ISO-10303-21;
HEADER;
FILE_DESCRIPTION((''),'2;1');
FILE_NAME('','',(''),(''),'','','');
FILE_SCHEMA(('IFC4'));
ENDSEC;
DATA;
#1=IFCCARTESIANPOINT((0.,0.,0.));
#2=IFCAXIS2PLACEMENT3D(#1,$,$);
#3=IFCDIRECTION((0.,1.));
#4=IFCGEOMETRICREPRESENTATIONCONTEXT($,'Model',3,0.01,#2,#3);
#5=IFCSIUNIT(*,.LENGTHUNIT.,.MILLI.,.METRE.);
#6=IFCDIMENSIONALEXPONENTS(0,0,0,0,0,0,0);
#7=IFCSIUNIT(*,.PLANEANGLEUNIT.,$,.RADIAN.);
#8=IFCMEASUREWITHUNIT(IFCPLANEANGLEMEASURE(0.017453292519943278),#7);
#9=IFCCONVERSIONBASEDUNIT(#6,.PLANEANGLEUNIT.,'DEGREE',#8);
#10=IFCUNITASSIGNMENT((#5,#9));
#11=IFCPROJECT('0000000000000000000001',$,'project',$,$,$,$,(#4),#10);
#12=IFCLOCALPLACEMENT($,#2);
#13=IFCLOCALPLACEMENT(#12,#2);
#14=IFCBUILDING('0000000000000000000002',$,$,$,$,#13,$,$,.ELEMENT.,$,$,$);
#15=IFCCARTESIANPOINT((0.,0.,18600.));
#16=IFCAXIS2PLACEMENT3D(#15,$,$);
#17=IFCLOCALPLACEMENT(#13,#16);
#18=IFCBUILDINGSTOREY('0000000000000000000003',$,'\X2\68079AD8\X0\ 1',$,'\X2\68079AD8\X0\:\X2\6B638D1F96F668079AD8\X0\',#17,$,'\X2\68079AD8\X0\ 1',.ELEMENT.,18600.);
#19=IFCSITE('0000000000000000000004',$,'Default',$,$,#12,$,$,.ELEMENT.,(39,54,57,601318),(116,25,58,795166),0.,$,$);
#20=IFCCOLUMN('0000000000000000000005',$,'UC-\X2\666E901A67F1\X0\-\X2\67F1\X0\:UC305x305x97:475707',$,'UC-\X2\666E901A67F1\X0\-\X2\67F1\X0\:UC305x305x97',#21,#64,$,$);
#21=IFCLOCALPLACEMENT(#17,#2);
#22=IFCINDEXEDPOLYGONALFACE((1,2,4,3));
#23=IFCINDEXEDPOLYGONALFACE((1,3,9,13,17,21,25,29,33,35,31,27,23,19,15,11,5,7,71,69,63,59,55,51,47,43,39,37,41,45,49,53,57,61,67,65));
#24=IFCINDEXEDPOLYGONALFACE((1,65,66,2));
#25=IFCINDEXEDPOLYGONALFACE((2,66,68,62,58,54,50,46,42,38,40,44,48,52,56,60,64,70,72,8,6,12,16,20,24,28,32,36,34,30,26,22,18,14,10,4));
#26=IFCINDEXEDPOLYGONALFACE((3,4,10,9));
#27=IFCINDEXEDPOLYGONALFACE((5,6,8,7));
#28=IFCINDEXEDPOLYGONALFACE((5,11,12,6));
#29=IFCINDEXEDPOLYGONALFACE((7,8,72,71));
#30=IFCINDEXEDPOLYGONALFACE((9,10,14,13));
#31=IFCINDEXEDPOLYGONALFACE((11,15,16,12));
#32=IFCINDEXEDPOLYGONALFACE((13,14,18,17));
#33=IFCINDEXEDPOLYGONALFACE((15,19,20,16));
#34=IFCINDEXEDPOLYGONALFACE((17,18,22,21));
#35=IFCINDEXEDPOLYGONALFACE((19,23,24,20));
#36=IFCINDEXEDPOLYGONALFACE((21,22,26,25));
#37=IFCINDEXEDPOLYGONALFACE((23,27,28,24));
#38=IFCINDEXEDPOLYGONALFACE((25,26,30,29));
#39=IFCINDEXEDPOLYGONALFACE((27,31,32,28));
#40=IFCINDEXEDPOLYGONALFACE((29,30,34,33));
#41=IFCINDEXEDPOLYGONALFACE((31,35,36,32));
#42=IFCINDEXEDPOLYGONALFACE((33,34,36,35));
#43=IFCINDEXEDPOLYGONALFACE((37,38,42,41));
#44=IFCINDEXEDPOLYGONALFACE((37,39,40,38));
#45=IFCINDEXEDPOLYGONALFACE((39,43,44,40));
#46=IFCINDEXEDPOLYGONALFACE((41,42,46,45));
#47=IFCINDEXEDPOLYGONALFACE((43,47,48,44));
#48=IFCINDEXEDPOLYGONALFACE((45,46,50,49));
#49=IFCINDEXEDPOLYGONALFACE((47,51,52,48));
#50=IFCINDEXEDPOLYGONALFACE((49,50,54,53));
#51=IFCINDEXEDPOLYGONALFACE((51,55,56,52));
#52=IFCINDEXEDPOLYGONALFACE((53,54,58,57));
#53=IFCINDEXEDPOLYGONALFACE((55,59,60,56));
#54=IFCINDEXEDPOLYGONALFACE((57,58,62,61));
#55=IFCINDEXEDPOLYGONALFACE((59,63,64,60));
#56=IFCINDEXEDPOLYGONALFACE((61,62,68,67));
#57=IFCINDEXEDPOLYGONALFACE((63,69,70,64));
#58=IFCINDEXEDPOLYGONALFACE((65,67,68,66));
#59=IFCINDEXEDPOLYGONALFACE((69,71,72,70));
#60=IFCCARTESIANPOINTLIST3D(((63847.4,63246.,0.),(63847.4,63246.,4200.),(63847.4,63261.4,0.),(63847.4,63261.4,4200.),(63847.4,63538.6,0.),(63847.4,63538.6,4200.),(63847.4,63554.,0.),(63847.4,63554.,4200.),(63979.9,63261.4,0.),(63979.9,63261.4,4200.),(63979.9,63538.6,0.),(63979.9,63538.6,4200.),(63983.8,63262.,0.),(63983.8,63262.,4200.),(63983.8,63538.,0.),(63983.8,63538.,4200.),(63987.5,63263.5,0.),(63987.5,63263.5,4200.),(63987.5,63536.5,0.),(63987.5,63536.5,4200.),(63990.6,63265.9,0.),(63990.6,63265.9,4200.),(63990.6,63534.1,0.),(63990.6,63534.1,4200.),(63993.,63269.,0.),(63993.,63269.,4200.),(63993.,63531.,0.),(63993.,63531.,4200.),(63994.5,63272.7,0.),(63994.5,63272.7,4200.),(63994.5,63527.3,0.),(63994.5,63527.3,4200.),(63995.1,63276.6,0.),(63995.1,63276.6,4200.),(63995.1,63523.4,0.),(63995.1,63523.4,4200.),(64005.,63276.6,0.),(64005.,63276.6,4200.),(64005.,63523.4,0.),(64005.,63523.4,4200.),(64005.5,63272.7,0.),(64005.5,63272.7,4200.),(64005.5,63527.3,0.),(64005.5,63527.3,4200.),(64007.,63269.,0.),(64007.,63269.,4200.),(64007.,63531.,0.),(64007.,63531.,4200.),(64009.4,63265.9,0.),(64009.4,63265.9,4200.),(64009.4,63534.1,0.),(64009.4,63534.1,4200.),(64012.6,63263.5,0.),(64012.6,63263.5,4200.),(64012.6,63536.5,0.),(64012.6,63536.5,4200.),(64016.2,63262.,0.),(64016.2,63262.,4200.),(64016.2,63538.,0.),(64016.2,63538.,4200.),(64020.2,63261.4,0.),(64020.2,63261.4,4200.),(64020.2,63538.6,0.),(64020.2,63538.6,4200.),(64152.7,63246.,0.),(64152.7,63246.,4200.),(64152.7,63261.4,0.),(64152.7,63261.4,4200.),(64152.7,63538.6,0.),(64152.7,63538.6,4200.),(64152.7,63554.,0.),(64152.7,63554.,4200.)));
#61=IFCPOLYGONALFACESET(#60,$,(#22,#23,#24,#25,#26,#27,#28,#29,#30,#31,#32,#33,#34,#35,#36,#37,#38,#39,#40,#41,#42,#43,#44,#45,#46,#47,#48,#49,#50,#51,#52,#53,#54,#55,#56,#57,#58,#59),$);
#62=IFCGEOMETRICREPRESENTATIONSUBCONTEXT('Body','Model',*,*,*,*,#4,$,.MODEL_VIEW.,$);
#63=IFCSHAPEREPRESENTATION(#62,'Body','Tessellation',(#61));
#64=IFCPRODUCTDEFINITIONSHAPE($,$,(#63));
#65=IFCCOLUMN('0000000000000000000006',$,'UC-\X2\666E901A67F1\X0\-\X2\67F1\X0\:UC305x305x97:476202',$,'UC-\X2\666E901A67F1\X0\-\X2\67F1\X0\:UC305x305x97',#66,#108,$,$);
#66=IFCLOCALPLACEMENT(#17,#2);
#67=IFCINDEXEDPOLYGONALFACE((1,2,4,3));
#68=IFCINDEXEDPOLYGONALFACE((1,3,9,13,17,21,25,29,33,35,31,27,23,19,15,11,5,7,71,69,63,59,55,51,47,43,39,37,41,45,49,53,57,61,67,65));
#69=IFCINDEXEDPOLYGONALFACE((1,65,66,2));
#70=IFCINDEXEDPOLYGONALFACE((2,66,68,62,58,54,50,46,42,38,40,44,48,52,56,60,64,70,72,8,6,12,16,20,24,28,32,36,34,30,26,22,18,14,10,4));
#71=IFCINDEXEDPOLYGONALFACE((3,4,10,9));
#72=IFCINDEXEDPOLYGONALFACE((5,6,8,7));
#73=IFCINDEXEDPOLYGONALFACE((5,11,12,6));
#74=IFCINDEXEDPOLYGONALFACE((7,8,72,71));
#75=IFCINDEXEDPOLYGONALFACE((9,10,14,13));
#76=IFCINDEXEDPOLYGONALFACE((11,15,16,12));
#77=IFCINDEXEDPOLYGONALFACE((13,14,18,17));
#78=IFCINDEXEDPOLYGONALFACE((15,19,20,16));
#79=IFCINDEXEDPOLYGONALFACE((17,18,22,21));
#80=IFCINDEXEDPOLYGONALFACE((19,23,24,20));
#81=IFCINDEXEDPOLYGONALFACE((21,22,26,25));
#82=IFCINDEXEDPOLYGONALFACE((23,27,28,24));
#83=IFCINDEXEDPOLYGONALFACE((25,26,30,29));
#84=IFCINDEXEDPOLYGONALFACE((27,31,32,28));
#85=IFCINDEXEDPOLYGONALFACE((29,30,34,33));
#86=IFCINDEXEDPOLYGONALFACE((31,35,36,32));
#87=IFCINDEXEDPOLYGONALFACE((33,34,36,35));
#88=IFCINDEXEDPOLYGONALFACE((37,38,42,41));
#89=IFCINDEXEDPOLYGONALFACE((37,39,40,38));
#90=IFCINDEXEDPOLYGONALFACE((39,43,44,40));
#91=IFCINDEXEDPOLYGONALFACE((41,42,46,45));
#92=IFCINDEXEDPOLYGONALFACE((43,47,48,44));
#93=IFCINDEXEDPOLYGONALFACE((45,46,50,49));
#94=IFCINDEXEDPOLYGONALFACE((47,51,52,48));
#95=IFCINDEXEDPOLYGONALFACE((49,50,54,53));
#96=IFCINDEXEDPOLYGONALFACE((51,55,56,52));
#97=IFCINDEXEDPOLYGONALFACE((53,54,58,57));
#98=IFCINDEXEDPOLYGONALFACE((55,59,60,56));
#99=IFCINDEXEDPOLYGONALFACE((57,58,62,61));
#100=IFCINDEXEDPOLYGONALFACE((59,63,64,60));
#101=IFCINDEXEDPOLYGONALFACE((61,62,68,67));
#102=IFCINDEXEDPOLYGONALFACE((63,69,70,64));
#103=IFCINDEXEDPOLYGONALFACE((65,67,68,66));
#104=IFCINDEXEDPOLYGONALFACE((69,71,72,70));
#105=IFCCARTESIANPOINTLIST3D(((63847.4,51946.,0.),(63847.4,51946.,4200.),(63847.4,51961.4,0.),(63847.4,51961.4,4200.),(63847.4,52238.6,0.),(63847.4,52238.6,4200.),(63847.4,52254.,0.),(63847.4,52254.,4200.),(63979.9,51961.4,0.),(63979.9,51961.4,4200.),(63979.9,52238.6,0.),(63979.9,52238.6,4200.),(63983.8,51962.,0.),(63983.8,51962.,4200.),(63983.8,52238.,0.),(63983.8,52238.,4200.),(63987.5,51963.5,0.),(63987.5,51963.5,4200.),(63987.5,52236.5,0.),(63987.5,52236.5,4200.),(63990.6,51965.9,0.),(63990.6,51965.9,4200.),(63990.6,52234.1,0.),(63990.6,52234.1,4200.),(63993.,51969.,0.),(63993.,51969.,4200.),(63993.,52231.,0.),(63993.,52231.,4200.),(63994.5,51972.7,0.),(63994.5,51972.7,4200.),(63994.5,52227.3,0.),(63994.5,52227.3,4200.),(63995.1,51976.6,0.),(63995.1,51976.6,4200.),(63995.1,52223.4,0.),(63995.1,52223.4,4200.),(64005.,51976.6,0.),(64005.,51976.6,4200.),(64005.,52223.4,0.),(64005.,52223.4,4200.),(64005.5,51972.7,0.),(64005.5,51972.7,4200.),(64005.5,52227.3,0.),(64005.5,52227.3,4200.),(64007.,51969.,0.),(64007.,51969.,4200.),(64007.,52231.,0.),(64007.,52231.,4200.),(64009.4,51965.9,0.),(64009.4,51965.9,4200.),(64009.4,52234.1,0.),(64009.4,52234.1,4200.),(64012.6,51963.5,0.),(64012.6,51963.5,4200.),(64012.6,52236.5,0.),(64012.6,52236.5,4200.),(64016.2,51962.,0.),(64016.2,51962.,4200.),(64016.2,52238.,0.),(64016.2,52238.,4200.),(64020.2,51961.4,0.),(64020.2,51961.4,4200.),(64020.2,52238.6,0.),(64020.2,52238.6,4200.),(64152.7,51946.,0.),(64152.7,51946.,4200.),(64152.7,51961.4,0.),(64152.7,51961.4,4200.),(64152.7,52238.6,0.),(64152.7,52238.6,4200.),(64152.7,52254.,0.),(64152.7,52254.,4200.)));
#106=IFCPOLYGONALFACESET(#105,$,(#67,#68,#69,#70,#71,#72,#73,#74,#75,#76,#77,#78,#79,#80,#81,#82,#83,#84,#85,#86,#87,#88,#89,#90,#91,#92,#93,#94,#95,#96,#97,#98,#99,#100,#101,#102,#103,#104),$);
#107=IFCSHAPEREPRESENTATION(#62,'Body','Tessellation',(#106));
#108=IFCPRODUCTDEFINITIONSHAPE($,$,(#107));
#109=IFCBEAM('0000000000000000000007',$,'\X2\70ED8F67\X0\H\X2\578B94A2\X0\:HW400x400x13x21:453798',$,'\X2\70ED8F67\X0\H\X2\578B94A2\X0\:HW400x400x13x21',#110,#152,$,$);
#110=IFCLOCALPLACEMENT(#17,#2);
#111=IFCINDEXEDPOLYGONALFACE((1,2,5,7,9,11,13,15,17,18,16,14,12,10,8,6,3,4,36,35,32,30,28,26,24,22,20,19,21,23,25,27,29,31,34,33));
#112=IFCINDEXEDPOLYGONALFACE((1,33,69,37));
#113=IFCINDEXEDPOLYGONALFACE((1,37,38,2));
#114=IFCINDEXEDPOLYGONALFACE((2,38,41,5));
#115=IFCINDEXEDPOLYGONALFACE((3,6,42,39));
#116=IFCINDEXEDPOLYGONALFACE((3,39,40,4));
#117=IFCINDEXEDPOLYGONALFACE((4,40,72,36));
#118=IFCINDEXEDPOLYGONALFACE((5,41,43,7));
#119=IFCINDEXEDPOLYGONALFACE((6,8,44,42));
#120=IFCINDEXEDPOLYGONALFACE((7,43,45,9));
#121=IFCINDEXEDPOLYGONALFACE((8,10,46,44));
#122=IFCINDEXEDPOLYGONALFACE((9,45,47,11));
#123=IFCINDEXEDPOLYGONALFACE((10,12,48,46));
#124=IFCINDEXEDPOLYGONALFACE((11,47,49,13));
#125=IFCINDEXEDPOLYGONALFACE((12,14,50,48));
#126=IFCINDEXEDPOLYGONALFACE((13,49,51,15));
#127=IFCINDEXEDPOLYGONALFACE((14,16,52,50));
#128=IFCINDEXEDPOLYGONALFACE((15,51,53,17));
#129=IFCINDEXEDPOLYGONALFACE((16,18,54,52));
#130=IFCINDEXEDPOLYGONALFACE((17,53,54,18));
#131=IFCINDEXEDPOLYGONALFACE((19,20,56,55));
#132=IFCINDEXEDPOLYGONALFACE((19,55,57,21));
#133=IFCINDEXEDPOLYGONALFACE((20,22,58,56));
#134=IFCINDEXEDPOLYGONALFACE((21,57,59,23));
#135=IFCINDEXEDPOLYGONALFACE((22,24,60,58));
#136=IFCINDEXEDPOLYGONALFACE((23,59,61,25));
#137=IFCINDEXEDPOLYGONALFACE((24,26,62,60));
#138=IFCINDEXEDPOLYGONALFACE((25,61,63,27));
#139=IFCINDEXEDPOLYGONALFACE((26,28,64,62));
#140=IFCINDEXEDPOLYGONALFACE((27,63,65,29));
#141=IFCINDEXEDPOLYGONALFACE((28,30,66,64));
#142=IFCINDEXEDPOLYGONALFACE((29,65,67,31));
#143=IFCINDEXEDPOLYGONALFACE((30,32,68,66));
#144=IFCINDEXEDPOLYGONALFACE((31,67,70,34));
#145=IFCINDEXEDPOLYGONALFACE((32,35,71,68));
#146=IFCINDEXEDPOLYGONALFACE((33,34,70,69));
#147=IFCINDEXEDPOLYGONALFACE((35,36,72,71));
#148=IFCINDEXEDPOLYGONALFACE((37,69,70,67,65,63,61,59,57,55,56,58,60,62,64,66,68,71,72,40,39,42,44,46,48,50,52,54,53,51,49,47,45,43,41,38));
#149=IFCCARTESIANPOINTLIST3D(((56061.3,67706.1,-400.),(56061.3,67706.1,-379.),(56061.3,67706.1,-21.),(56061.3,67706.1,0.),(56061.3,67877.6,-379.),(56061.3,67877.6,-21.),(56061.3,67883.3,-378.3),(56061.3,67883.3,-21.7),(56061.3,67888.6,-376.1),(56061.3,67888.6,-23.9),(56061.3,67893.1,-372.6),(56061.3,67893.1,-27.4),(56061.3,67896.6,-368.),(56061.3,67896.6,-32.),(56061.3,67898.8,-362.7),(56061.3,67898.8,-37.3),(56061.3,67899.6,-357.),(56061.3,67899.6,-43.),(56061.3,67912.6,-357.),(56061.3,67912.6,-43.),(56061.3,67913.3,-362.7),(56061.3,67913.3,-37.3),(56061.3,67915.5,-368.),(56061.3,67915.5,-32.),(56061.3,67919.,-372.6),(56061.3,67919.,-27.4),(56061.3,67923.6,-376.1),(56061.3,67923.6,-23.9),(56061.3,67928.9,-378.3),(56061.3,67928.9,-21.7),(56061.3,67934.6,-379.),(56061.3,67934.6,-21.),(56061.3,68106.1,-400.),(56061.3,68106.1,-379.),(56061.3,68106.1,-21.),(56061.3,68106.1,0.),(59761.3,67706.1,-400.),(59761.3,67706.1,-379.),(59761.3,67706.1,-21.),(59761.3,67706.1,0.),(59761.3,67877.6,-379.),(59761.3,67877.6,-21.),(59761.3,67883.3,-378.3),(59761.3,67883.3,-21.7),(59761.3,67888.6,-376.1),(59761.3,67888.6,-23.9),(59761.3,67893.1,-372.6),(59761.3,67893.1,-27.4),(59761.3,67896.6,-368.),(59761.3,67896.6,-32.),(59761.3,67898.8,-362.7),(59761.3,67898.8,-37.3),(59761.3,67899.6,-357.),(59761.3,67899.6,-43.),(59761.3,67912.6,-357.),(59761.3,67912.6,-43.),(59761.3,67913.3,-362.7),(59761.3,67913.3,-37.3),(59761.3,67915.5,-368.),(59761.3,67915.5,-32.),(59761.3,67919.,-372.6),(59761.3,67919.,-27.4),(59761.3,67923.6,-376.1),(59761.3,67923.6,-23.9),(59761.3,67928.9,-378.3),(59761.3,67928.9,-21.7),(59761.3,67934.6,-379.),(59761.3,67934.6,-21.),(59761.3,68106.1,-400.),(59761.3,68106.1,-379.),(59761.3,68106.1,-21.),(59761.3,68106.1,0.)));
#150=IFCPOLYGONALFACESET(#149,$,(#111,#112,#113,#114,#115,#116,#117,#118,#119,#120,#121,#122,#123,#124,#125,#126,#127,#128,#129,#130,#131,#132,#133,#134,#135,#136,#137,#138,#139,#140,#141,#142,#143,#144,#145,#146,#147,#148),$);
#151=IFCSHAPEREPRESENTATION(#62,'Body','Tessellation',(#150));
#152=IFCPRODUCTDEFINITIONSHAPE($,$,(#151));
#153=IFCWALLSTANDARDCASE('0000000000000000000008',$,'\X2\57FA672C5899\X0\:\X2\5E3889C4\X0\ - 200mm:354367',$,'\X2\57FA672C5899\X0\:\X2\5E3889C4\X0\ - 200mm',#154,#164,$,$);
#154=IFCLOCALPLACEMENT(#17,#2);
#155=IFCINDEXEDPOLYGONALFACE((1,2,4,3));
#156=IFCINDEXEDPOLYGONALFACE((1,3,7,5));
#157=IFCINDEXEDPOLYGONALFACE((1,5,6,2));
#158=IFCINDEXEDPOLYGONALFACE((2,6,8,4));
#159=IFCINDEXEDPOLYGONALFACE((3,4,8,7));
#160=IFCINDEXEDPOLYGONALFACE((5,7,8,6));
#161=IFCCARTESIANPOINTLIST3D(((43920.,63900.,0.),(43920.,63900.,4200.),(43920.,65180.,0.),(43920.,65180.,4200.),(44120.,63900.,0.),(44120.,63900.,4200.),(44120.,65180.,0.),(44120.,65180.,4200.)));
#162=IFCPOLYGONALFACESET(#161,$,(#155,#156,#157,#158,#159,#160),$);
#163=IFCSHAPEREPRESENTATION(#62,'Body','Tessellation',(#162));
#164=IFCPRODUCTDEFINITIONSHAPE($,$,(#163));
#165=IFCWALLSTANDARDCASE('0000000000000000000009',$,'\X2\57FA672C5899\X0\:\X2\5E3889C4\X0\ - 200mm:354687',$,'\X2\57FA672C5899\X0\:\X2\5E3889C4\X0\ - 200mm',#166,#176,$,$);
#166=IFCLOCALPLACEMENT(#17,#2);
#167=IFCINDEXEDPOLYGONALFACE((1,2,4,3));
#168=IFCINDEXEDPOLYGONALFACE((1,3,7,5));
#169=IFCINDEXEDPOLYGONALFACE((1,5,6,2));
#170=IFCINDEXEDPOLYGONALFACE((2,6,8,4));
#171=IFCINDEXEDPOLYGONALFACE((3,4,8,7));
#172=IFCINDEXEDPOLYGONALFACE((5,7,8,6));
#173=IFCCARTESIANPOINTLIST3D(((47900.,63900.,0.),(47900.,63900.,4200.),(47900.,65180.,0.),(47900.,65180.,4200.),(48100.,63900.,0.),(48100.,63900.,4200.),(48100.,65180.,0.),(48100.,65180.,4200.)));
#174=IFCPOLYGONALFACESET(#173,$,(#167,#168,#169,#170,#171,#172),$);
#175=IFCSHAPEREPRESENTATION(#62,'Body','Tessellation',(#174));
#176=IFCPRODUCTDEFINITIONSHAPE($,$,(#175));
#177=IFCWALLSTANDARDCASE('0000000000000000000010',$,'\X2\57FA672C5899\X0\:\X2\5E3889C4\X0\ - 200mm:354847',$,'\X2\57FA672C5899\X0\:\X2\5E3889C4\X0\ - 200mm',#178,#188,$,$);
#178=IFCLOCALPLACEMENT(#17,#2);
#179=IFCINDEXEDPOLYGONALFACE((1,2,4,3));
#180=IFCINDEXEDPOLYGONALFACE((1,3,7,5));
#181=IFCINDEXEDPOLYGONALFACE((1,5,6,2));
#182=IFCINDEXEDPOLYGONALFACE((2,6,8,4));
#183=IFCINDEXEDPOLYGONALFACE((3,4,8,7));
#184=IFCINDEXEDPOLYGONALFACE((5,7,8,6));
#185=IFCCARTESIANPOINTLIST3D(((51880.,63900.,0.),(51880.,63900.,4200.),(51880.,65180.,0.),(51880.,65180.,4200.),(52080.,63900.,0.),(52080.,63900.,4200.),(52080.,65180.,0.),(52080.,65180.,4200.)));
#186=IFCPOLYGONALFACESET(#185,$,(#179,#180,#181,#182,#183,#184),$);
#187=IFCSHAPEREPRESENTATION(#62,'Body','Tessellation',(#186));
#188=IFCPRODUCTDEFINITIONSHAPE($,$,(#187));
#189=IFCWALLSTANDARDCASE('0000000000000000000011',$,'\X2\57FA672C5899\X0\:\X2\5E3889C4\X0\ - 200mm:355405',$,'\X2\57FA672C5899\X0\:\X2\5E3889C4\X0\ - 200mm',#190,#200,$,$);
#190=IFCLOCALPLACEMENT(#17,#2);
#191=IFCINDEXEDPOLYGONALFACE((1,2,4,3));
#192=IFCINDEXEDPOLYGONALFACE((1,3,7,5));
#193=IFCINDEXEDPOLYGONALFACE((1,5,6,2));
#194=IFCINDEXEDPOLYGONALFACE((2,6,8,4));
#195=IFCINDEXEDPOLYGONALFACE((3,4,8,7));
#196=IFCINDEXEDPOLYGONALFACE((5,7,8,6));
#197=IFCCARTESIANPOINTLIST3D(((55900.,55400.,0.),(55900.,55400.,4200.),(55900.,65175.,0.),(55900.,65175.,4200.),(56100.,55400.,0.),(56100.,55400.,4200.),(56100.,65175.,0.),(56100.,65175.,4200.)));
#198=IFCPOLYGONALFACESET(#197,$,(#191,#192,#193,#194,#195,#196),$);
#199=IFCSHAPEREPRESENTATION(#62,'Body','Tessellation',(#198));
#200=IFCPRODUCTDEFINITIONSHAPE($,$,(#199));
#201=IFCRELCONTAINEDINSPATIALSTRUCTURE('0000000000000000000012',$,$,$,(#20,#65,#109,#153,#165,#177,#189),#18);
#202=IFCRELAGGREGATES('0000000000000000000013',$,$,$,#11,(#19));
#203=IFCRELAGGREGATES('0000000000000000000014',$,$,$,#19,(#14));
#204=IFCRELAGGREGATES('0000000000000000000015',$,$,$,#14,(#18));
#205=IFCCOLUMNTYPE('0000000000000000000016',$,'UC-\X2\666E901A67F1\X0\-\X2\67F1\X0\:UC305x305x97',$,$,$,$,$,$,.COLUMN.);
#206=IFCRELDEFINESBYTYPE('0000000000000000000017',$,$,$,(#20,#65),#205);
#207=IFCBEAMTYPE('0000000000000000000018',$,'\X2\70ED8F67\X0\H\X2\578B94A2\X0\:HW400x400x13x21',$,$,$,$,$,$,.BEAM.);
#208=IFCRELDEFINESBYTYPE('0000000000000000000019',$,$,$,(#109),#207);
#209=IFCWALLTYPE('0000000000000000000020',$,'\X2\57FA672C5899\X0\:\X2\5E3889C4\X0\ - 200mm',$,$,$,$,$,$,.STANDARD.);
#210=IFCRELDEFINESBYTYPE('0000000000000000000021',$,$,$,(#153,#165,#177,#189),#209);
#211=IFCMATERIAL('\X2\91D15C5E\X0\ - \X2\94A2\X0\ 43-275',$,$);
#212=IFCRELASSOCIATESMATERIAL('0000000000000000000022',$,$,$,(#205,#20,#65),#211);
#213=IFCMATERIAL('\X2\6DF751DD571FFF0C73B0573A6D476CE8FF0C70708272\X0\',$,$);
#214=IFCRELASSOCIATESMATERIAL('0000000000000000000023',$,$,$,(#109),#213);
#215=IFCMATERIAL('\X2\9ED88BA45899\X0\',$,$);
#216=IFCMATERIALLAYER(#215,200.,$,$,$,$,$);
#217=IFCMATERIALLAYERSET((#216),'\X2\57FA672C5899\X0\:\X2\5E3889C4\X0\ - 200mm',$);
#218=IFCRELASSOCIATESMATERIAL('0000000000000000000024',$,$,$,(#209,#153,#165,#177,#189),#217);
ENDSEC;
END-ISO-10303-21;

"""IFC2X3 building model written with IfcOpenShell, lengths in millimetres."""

from ifc_helpers import new_model, entity, si_unit, converted_unit, direction, frame, frame_2d, origin, origin_2d_with_axis, place, context, subcontext, project, spatial, rectangle, i_section, extrude, source, transform, mapped, material, layer, layer_set, layer_usage, type_object, type_shapes, element, save


model = new_model("IFC2X3")

# Units and contexts
model_context = context("Model", 3, precision=0.01, world=origin(), true_north=direction((0.0, 1.0)))
body_context = subcontext(model_context, "Body", "Model", "MODEL_VIEW")
ifc_project = project(units=[si_unit("LENGTHUNIT", "METRE", prefix="MILLI"), converted_unit("PLANEANGLEUNIT", "DEGREE", entity("IfcPlaneAngleMeasure", 0.017453292519943278), si_unit("PLANEANGLEUNIT", "RADIAN"), dimensions=[0, 0, 0, 0, 0, 0, 0])], contexts=[model_context])

# Site, building, storey
site_placement = place(None, origin())
site = spatial("IfcSite", under=ifc_project, at=site_placement, Name="Default", CompositionType="ELEMENT", RefLatitude=(39, 54, 57, 601318), RefLongitude=(116, 25, 58, 795166), RefElevation=0.0)
building_placement = place(site_placement, origin())
building = spatial("IfcBuilding", under=site, at=building_placement, CompositionType="ELEMENT")
storey_placement = place(building_placement, frame((0.0, 0.0, 18600.0)))
storey = spatial("IfcBuildingStorey", under=building, at=storey_placement, Name="标高 1", ObjectType="标高:正负零标高", LongName="标高 1", CompositionType="ELEMENT", Elevation=18600.0)

# Columns
ifc_material_1 = material(Name="金属 - 钢 43-275")
column_type = type_object("IfcColumnType", Name="UC-普通柱-柱:UC305x305x97", PredefinedType="COLUMN", material=ifc_material_1)
shared_shape_1 = source(origin(), body_context, "Body", "SweptSolid", [
    extrude(i_section(OverallWidth=305.3, OverallDepth=307.9, WebThickness=9.9, FlangeThickness=15.4, FilletRadius=15.2, at=origin_2d_with_axis()), frame((0.0, 0.0, 18600.0), z_axis=(0.0, 0.0, 1.0), x_axis=(-1.0, 0.0, 0.0)), (0.0, 0.0, 1.0), 4200.0),
])
type_shapes(column_type, [shared_shape_1])
for number, where, name in (
    (1, (64000.0, 63400.0, -18600.0), "UC-普通柱-柱:UC305x305x97:475707"),
    (2, (64000.0, 52100.0, -18600.0), "UC-普通柱-柱:UC305x305x97:476202"),
):
    element("IfcColumn", number, at=place(storey_placement, frame(where)), inside=storey, type_object=column_type, material=ifc_material_1, Name=name, ObjectType="UC-普通柱-柱:UC305x305x97", context=body_context, shape_type="MappedRepresentation", body=[
        mapped(shared_shape_1, transform((0.0, 0.0, 0.0), scale=1.0)),
    ])

# Beam
ifc_material_2 = material(Name="混凝土，现场浇注，灰色")
beam_type = type_object("IfcBeamType", Name="热轧H型钢:HW400x400x13x21", PredefinedType="BEAM")
beam_placement = place(storey_placement, frame((56061.3, 67906.1, 0.0)))
element("IfcBeam", 3, at=beam_placement, inside=storey, type_object=beam_type, material=ifc_material_2, Name="热轧H型钢:HW400x400x13x21:453798", ObjectType="热轧H型钢:HW400x400x13x21", context=body_context, shape_type="SweptSolid", body=[
    extrude(i_section(OverallWidth=400.0, OverallDepth=400.0, WebThickness=13.0, FlangeThickness=21.0, FilletRadius=22.0, at=frame_2d((0.0, 0.0), x_axis=(0.0, 1.0))), frame((0.0, 0.0, -200.0), z_axis=(1.0, 0.0, 0.0), x_axis=(0.0, 0.0, -1.0)), (0.0, 0.0, 1.0), 3700.0),
])

# Walls
ifc_material_3 = material(Name="默认墙")
ifc_layer = layer(ifc_material_3, 200.0)
ifc_layer_set = layer_set([ifc_layer], Name="基本墙:常规 - 200mm")
ifc_layer_usage_1 = layer_usage(ifc_layer_set, "AXIS2", "NEGATIVE", 100.0)
wall_type = type_object("IfcWallType", Name="基本墙:常规 - 200mm", PredefinedType="STANDARD", material=ifc_layer_set)
wall_1_placement = place(storey_placement, frame((44020.0, 63900.0, 0.0), z_axis=(0.0, 0.0, 1.0), x_axis=(0.0, 1.0, 0.0)))
element("IfcWallStandardCase", 4, at=wall_1_placement, inside=storey, type_object=wall_type, material=ifc_layer_usage_1, Name="基本墙:常规 - 200mm:354367", ObjectType="基本墙:常规 - 200mm", context=body_context, shape_type="SweptSolid", body=[
    extrude(rectangle(XDim=1280.0, YDim=200.0, at=frame_2d((640.0, 0.0), x_axis=(-1.0, 0.0))), origin(), (0.0, 0.0, 1.0), 4200.0),
])
ifc_layer_usage_2 = layer_usage(ifc_layer_set, "AXIS2", "NEGATIVE", 100.0)
wall_2_placement = place(storey_placement, frame((48000.0, 63900.0, 0.0), z_axis=(0.0, 0.0, 1.0), x_axis=(0.0, 1.0, 0.0)))
element("IfcWallStandardCase", 5, at=wall_2_placement, inside=storey, type_object=wall_type, material=ifc_layer_usage_2, Name="基本墙:常规 - 200mm:354687", ObjectType="基本墙:常规 - 200mm", context=body_context, shape_type="SweptSolid", body=[
    extrude(rectangle(XDim=1280.0, YDim=200.0, at=frame_2d((640.0, 0.0), x_axis=(-1.0, 0.0))), origin(), (0.0, 0.0, 1.0), 4200.0),
])
ifc_layer_usage_3 = layer_usage(ifc_layer_set, "AXIS2", "NEGATIVE", 100.0)
wall_3_placement = place(storey_placement, frame((51980.0, 63900.0, 0.0), z_axis=(0.0, 0.0, 1.0), x_axis=(0.0, 1.0, 0.0)))
element("IfcWallStandardCase", 6, at=wall_3_placement, inside=storey, type_object=wall_type, material=ifc_layer_usage_3, Name="基本墙:常规 - 200mm:354847", ObjectType="基本墙:常规 - 200mm", context=body_context, shape_type="SweptSolid", body=[
    extrude(rectangle(XDim=1280.0, YDim=200.0, at=frame_2d((640.0, 0.0), x_axis=(-1.0, 0.0))), origin(), (0.0, 0.0, 1.0), 4200.0),
])
ifc_layer_usage_4 = layer_usage(ifc_layer_set, "AXIS2", "NEGATIVE", 100.0)
wall_4_placement = place(storey_placement, frame((56000.0, 65175.0, 0.0), z_axis=(0.0, 0.0, 1.0), x_axis=(0.0, -1.0, 0.0)))
element("IfcWallStandardCase", 7, at=wall_4_placement, inside=storey, type_object=wall_type, material=ifc_layer_usage_4, Name="基本墙:常规 - 200mm:355405", ObjectType="基本墙:常规 - 200mm", context=body_context, shape_type="SweptSolid", body=[
    extrude(rectangle(XDim=9775.0, YDim=200.0, at=frame_2d((4887.5, 0.0), x_axis=(-1.0, 0.0))), origin(), (0.0, 0.0, 1.0), 4200.0),
])

save(model, "model.ifc")
